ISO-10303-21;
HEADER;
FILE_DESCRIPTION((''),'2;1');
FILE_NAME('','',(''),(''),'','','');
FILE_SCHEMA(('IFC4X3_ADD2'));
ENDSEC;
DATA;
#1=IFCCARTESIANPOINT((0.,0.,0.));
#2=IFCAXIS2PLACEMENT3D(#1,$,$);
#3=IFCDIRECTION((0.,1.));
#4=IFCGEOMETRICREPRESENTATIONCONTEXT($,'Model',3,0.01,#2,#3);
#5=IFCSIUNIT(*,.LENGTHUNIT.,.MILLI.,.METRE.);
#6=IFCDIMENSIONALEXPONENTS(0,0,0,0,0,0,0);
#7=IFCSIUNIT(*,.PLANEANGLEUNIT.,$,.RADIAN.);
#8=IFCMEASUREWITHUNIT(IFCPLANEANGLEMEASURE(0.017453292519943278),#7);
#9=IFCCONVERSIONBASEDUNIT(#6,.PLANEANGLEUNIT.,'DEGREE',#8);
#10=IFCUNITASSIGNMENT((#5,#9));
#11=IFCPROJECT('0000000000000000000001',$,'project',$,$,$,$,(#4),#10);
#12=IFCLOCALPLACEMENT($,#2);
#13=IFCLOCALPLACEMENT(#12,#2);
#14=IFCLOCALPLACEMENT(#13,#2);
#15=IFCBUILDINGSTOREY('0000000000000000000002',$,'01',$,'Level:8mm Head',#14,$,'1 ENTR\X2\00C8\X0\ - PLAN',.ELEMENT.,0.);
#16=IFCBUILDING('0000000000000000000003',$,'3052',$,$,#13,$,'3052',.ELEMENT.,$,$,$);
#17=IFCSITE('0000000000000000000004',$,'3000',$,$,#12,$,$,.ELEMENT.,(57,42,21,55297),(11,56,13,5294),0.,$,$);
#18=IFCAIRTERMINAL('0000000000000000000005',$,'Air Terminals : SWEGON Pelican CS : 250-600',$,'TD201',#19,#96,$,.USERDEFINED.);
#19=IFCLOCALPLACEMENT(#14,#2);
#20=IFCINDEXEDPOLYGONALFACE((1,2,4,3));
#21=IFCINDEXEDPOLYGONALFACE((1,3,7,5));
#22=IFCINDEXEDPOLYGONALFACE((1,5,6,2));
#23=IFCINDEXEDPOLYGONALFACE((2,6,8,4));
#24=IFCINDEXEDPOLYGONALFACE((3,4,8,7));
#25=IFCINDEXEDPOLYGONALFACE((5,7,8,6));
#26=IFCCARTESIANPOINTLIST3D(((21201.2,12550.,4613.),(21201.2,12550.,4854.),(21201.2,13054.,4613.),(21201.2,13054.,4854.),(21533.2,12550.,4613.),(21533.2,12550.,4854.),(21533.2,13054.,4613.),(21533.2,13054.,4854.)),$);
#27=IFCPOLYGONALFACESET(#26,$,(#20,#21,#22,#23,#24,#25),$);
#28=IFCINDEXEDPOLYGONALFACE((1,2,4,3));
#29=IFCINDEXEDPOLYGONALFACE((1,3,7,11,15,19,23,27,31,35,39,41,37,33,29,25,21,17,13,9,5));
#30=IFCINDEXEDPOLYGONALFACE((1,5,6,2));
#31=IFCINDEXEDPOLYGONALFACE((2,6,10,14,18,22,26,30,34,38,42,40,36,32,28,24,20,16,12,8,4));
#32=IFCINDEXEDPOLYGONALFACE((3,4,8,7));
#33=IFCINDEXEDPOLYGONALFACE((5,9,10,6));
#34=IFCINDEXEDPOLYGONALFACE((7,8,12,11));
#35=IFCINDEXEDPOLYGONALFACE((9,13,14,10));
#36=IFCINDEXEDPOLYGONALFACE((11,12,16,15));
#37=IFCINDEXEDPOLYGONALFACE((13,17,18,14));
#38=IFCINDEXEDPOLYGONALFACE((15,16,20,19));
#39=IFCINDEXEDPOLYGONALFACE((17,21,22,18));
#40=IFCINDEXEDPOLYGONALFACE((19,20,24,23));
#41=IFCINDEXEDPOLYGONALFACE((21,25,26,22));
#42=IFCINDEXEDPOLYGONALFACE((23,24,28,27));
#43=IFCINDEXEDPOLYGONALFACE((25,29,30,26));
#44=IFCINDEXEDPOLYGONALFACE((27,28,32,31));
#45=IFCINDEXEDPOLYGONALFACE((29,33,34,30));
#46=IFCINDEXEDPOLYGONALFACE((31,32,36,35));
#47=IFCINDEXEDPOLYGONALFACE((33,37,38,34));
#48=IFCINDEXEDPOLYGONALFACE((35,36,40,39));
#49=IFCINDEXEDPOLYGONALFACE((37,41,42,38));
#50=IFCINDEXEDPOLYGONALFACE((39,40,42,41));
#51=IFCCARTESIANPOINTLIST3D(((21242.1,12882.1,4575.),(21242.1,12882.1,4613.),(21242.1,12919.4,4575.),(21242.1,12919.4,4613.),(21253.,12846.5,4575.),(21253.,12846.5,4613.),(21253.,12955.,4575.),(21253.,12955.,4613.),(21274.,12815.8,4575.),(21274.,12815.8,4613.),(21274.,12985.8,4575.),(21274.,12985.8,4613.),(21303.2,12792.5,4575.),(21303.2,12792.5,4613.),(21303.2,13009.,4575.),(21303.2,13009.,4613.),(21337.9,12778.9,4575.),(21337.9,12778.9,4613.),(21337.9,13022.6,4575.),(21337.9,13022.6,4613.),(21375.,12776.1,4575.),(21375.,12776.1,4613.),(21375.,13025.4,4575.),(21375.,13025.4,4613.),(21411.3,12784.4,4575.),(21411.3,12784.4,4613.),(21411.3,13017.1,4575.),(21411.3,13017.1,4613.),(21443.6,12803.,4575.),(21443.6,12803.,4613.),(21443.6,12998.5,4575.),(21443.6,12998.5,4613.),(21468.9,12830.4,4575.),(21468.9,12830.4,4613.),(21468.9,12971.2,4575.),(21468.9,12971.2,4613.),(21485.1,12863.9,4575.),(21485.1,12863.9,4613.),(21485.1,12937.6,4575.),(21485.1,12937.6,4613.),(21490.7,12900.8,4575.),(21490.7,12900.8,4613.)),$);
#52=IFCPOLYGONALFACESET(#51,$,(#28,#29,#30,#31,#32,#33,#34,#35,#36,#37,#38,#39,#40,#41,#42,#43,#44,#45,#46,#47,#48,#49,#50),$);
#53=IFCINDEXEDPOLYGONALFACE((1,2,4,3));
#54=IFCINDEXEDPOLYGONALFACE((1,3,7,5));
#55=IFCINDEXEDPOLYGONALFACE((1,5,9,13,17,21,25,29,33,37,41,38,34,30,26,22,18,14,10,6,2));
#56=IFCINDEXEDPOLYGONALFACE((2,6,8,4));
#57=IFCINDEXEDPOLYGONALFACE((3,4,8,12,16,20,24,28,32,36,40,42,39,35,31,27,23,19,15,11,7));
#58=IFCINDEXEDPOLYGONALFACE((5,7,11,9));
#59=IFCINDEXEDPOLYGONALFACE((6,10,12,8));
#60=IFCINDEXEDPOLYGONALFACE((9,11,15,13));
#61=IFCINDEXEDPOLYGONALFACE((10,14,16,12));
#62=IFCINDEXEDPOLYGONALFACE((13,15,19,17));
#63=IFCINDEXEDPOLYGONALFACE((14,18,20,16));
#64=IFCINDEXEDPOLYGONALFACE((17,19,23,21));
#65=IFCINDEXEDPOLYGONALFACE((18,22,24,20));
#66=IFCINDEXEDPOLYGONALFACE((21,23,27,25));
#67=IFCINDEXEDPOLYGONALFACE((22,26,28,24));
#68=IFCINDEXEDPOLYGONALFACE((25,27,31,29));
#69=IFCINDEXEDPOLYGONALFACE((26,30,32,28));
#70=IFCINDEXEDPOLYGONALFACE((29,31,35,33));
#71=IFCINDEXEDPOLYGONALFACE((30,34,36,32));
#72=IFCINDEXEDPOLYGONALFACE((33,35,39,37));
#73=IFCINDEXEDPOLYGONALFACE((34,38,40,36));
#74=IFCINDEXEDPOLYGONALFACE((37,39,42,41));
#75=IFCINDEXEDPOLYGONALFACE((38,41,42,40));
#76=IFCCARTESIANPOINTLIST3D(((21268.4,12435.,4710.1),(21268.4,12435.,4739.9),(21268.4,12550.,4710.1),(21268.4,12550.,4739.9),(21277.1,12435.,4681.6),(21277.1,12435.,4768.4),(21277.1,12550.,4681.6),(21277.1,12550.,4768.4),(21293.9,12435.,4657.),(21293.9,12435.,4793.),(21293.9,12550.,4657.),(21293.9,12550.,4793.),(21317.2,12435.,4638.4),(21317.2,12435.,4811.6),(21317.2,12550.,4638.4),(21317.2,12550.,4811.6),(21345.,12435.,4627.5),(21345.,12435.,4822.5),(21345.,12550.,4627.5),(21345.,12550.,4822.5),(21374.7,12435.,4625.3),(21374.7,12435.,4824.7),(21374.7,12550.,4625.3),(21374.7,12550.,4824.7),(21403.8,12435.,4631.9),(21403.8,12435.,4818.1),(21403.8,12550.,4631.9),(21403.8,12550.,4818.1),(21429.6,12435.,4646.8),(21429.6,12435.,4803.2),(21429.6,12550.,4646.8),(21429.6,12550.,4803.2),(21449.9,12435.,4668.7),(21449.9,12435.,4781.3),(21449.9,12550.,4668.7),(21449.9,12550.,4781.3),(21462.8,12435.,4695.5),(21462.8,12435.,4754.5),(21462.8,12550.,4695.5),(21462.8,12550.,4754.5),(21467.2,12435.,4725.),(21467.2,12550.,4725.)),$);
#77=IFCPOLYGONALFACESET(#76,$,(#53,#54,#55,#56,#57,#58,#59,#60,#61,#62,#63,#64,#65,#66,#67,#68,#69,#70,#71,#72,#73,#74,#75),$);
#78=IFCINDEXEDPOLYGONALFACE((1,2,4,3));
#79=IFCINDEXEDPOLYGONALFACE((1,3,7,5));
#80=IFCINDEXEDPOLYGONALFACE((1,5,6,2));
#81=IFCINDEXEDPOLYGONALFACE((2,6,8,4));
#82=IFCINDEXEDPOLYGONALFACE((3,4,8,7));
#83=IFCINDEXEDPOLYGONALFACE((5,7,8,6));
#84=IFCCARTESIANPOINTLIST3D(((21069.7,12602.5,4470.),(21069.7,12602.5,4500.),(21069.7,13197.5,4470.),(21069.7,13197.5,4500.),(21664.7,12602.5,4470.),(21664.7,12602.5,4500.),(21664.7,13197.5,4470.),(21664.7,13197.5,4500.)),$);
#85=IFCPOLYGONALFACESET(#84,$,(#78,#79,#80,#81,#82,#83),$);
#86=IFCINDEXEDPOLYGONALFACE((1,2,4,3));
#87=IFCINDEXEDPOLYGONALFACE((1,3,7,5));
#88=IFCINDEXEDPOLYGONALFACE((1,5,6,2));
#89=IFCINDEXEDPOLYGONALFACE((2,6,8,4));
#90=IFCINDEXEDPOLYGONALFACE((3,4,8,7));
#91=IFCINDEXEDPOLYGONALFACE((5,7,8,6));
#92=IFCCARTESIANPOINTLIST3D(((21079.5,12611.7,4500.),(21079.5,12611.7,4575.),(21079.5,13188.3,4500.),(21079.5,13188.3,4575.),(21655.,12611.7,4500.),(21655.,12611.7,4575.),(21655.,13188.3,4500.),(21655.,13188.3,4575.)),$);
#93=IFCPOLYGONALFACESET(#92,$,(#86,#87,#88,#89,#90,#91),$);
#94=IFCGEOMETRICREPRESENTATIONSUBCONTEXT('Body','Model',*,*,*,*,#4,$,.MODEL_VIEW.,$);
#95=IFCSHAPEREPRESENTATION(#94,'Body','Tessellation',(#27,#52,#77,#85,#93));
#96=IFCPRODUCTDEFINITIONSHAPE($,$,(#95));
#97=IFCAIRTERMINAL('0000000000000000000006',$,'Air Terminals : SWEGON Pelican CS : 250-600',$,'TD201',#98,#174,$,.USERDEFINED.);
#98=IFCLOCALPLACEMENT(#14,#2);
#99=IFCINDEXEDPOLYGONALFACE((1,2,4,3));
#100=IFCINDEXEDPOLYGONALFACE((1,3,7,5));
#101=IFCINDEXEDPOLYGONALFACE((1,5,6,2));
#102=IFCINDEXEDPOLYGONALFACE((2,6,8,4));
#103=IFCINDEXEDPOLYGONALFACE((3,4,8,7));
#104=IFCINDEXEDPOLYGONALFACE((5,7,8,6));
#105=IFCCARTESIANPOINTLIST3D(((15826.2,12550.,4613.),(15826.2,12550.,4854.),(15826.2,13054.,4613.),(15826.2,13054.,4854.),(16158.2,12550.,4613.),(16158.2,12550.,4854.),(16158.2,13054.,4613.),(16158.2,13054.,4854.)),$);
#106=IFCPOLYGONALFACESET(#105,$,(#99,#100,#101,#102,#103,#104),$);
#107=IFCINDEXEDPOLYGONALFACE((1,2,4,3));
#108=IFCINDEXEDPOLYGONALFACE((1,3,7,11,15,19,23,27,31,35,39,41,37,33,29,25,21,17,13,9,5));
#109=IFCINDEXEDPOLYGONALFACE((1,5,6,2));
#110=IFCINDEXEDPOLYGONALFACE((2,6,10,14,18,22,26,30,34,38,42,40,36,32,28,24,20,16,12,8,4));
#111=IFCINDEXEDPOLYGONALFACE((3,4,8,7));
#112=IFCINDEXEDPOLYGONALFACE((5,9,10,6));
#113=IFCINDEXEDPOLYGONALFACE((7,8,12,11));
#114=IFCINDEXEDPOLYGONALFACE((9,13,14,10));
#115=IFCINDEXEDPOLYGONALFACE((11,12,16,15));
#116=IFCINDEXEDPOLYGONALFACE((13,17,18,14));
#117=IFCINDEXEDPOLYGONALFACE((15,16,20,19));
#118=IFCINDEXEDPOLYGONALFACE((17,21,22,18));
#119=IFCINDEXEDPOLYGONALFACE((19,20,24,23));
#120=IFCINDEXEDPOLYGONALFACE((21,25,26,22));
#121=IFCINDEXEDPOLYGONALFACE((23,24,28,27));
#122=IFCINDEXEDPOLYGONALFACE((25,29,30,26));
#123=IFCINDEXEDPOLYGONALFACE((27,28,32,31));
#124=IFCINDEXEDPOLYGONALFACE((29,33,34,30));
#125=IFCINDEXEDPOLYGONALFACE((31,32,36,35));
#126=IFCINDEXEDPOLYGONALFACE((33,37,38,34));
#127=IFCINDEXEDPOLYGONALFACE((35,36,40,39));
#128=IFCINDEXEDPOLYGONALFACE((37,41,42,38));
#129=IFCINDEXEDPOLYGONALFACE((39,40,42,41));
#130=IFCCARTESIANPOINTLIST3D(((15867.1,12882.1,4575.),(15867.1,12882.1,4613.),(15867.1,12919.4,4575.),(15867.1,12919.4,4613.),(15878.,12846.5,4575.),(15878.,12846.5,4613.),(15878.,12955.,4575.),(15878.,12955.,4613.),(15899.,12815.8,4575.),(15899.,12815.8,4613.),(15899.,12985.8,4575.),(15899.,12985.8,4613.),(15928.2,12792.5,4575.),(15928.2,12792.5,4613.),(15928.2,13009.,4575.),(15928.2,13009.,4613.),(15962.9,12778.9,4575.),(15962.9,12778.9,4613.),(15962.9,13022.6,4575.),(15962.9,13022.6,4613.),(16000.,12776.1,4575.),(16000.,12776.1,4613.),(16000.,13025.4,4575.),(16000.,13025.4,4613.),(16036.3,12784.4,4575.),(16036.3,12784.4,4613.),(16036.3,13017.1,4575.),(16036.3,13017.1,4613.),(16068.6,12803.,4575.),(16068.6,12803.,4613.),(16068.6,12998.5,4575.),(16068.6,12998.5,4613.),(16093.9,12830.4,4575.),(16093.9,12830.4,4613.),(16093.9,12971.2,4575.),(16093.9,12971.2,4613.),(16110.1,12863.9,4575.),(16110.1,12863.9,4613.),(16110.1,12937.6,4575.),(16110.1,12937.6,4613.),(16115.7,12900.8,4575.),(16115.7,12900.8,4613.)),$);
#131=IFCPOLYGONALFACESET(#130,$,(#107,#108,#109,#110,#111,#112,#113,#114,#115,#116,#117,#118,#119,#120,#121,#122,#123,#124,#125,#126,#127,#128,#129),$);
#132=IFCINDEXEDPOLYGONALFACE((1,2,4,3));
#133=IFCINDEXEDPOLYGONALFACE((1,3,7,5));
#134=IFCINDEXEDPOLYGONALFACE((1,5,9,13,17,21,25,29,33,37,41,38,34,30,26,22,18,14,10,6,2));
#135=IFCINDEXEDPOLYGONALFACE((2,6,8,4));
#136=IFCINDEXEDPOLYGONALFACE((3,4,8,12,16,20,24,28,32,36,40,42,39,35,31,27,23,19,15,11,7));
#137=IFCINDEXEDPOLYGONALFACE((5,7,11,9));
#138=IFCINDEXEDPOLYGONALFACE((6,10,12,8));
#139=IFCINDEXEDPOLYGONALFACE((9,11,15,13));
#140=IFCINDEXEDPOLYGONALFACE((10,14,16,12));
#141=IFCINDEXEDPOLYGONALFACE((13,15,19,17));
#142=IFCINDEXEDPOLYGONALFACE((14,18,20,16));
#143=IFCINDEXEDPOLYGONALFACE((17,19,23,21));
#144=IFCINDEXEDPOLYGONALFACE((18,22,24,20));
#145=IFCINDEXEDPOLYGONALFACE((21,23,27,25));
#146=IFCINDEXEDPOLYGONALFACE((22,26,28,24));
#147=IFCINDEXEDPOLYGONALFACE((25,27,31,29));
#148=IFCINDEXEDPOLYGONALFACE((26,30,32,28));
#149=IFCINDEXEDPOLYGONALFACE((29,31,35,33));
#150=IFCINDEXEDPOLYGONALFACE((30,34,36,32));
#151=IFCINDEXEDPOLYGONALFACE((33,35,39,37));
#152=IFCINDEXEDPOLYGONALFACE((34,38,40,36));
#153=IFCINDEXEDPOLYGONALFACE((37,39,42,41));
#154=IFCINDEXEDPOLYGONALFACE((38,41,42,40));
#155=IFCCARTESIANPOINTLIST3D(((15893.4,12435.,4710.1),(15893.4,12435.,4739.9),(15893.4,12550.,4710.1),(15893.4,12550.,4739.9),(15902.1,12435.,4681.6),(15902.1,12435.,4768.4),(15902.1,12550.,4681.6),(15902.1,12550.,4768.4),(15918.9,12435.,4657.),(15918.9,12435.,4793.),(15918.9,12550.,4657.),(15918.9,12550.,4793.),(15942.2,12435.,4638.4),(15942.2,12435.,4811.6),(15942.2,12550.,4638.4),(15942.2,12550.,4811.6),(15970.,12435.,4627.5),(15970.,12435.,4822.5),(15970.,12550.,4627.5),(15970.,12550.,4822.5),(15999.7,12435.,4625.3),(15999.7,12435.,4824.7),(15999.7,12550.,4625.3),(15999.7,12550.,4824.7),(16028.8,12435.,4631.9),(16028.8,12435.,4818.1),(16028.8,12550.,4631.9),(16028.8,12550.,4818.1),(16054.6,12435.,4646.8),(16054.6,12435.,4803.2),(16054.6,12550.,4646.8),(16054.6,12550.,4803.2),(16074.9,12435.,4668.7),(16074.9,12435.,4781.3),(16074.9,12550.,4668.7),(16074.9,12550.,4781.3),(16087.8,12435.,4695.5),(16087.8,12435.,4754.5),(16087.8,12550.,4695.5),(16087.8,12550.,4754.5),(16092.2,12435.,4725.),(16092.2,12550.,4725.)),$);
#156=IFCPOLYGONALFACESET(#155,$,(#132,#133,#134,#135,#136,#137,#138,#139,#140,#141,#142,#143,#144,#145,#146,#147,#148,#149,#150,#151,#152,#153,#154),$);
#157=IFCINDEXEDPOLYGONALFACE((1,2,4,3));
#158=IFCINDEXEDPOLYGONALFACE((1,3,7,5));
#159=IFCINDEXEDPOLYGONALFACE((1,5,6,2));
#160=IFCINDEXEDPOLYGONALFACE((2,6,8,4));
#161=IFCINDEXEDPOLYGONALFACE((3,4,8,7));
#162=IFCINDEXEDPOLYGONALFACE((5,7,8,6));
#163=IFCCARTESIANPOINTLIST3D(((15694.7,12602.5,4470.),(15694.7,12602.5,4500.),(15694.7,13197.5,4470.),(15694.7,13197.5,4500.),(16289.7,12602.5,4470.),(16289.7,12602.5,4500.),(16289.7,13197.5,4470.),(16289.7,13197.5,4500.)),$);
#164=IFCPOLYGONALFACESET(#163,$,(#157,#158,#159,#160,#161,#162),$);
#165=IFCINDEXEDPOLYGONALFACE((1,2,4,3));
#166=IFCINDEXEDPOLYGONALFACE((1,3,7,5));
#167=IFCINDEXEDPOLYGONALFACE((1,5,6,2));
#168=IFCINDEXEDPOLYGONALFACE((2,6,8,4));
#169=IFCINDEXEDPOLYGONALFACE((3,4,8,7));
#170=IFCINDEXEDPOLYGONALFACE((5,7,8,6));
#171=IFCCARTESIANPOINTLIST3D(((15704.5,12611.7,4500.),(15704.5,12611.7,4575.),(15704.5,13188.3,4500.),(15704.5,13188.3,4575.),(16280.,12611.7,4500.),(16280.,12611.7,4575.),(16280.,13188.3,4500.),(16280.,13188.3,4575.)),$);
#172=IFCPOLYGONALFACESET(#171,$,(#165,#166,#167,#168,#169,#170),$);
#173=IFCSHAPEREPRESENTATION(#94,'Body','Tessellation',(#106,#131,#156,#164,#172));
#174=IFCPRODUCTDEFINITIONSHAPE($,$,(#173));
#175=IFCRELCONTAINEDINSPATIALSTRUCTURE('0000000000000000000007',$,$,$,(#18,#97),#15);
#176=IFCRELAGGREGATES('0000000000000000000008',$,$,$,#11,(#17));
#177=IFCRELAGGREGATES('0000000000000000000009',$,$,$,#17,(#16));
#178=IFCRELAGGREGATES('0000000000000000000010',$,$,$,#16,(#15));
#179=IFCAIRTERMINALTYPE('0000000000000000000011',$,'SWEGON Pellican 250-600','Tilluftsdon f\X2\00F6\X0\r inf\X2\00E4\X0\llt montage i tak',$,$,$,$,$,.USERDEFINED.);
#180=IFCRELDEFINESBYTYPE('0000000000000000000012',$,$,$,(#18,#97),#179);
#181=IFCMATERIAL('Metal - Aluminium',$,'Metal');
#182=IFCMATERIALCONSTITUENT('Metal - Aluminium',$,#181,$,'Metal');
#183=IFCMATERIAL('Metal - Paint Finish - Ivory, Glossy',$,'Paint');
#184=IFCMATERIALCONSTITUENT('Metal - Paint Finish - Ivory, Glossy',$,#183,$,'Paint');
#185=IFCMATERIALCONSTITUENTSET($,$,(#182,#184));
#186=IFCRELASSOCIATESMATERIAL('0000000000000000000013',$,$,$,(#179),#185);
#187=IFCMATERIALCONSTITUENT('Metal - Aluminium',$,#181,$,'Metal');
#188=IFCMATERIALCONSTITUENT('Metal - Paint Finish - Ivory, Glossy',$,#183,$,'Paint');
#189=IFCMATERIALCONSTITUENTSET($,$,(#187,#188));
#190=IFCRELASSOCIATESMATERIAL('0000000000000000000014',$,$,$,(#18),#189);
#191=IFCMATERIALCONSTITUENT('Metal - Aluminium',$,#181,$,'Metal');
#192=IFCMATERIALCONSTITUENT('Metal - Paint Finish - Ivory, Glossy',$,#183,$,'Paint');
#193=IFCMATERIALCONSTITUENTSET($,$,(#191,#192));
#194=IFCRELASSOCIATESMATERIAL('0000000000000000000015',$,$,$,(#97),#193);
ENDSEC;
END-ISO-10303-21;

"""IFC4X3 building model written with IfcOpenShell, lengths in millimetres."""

from ifc_helpers import new_model, entity, si_unit, converted_unit, direction, frame, frame_2d, origin, origin_2d_with_axis, place, context, subcontext, project, spatial, rectangle, circle, extrude, source, transform, mapped, material, constituent, constituent_set, type_object, type_shapes, element, save


model = new_model("IFC4X3")

# Units and contexts
model_context = context("Model", 3, precision=0.01, world=origin(), true_north=direction((0.0, 1.0)))
body_context = subcontext(model_context, "Body", "Model", "MODEL_VIEW")
ifc_project = project(units=[si_unit("LENGTHUNIT", "METRE", prefix="MILLI"), converted_unit("PLANEANGLEUNIT", "DEGREE", entity("IfcPlaneAngleMeasure", 0.017453292519943278), si_unit("PLANEANGLEUNIT", "RADIAN"), dimensions=[0, 0, 0, 0, 0, 0, 0])], contexts=[model_context])

# Site, building, storey
site_placement = place(None, origin())
site = spatial("IfcSite", under=ifc_project, at=site_placement, Name="3000", CompositionType="ELEMENT", RefLatitude=(57, 42, 21, 55297), RefLongitude=(11, 56, 13, 5294), RefElevation=0.0)
building_placement = place(site_placement, origin())
building = spatial("IfcBuilding", under=site, at=building_placement, Name="3052", LongName="3052", CompositionType="ELEMENT")
storey_placement = place(building_placement, origin())
storey = spatial("IfcBuildingStorey", under=building, at=storey_placement, Name="01", ObjectType="Level:8mm Head", LongName="1 ENTRÈ - PLAN", CompositionType="ELEMENT", Elevation=0.0)

# Shared definitions
ifc_material_1 = material(Name="Metal - Aluminium", Category="Metal")
ifc_material_2 = material(Name="Metal - Paint Finish - Ivory, Glossy", Category="Paint")

# Air terminals
ifc_constituent_1 = constituent(ifc_material_1, Name="Metal - Aluminium", Category="Metal")
ifc_constituent_2 = constituent(ifc_material_2, Name="Metal - Paint Finish - Ivory, Glossy", Category="Paint")
ifc_constituent_set_1 = constituent_set(constituents=[ifc_constituent_1, ifc_constituent_2])
air_terminal_type_1 = type_object("IfcAirTerminalType", Name="SWEGON Pellican 250-600", Description="Tilluftsdon för infällt montage i tak", PredefinedType="USERDEFINED", material=ifc_constituent_set_1)
shared_shape_1 = source(origin(), body_context, "Body", "SweptSolid", [
    extrude(rectangle(XDim=332.0, YDim=504.0, at=origin_2d_with_axis()), frame((0.0, 98.0, -354.0), z_axis=(0.0, 0.0, 1.0), x_axis=(-1.0, 0.0, 0.0)), (0.0, 0.0, 1.0), 241.0),
    extrude(circle(Radius=125.0, at=frame_2d((0.0, 0.0), x_axis=(1.0, 0.0))), frame((-1.6, -0.8, -113.0)), (0.0, 0.0, 1.0), 38.0),
    extrude(circle(Radius=100.0, at=frame_2d((0.0, 0.0), x_axis=(1.0, 0.0))), frame((0.0, 350.0, -225.0), z_axis=(0.0, 1.0, 0.0), x_axis=(1.0, 0.0, 0.0)), (0.0, 0.0, 1.0), 115.0),
    extrude(rectangle(XDim=595.0, YDim=595.0, at=frame_2d((0.0, 0.0), x_axis=(1.0, 0.0))), frame((0.0, 0.0, 0.0), z_axis=(0.0, 0.0, 1.0), x_axis=(-1.0, 0.0, 0.0)), (0.0, 0.0, 1.0), 30.0),
    extrude(rectangle(XDim=575.5, YDim=576.5, at=origin_2d_with_axis()), frame((0.0, 0.0, -75.0), z_axis=(0.0, 0.0, 1.0), x_axis=(-1.0, 0.0, 0.0)), (0.0, 0.0, 1.0), 75.0),
])
type_shapes(air_terminal_type_1, [shared_shape_1])
ifc_constituent_3 = constituent(ifc_material_1, Name="Metal - Aluminium", Category="Metal")
ifc_constituent_4 = constituent(ifc_material_2, Name="Metal - Paint Finish - Ivory, Glossy", Category="Paint")
ifc_constituent_set_2 = constituent_set(constituents=[ifc_constituent_3, ifc_constituent_4])
air_terminal_1_placement = place(storey_placement, frame((21367.2, 12900.0, 4500.0), z_axis=(0.0, 0.0, -1.0), x_axis=(1.0, 0.0, 0.0)))
element("IfcAirTerminal", 1, at=air_terminal_1_placement, inside=storey, type_object=air_terminal_type_1, material=ifc_constituent_set_2, Name="Air Terminals : SWEGON Pelican CS : 250-600", ObjectType="TD201", PredefinedType="USERDEFINED", context=body_context, shape_type="MappedRepresentation", body=[
    mapped(shared_shape_1, transform((0.0, 0.0, 0.0), scale=1.0)),
])
ifc_constituent_5 = constituent(ifc_material_1, Name="Metal - Aluminium", Category="Metal")
ifc_constituent_6 = constituent(ifc_material_2, Name="Metal - Paint Finish - Ivory, Glossy", Category="Paint")
ifc_constituent_set_3 = constituent_set(constituents=[ifc_constituent_5, ifc_constituent_6])
air_terminal_2_placement = place(storey_placement, frame((15992.2, 12900.0, 4500.0), z_axis=(0.0, 0.0, -1.0), x_axis=(1.0, 0.0, 0.0)))
element("IfcAirTerminal", 2, at=air_terminal_2_placement, inside=storey, type_object=air_terminal_type_1, material=ifc_constituent_set_3, Name="Air Terminals : SWEGON Pelican CS : 250-600", ObjectType="TD201", PredefinedType="USERDEFINED", context=body_context, shape_type="MappedRepresentation", body=[
    mapped(shared_shape_1, transform((0.0, 0.0, 0.0), scale=1.0)),
])

save(model, "model.ifc")
